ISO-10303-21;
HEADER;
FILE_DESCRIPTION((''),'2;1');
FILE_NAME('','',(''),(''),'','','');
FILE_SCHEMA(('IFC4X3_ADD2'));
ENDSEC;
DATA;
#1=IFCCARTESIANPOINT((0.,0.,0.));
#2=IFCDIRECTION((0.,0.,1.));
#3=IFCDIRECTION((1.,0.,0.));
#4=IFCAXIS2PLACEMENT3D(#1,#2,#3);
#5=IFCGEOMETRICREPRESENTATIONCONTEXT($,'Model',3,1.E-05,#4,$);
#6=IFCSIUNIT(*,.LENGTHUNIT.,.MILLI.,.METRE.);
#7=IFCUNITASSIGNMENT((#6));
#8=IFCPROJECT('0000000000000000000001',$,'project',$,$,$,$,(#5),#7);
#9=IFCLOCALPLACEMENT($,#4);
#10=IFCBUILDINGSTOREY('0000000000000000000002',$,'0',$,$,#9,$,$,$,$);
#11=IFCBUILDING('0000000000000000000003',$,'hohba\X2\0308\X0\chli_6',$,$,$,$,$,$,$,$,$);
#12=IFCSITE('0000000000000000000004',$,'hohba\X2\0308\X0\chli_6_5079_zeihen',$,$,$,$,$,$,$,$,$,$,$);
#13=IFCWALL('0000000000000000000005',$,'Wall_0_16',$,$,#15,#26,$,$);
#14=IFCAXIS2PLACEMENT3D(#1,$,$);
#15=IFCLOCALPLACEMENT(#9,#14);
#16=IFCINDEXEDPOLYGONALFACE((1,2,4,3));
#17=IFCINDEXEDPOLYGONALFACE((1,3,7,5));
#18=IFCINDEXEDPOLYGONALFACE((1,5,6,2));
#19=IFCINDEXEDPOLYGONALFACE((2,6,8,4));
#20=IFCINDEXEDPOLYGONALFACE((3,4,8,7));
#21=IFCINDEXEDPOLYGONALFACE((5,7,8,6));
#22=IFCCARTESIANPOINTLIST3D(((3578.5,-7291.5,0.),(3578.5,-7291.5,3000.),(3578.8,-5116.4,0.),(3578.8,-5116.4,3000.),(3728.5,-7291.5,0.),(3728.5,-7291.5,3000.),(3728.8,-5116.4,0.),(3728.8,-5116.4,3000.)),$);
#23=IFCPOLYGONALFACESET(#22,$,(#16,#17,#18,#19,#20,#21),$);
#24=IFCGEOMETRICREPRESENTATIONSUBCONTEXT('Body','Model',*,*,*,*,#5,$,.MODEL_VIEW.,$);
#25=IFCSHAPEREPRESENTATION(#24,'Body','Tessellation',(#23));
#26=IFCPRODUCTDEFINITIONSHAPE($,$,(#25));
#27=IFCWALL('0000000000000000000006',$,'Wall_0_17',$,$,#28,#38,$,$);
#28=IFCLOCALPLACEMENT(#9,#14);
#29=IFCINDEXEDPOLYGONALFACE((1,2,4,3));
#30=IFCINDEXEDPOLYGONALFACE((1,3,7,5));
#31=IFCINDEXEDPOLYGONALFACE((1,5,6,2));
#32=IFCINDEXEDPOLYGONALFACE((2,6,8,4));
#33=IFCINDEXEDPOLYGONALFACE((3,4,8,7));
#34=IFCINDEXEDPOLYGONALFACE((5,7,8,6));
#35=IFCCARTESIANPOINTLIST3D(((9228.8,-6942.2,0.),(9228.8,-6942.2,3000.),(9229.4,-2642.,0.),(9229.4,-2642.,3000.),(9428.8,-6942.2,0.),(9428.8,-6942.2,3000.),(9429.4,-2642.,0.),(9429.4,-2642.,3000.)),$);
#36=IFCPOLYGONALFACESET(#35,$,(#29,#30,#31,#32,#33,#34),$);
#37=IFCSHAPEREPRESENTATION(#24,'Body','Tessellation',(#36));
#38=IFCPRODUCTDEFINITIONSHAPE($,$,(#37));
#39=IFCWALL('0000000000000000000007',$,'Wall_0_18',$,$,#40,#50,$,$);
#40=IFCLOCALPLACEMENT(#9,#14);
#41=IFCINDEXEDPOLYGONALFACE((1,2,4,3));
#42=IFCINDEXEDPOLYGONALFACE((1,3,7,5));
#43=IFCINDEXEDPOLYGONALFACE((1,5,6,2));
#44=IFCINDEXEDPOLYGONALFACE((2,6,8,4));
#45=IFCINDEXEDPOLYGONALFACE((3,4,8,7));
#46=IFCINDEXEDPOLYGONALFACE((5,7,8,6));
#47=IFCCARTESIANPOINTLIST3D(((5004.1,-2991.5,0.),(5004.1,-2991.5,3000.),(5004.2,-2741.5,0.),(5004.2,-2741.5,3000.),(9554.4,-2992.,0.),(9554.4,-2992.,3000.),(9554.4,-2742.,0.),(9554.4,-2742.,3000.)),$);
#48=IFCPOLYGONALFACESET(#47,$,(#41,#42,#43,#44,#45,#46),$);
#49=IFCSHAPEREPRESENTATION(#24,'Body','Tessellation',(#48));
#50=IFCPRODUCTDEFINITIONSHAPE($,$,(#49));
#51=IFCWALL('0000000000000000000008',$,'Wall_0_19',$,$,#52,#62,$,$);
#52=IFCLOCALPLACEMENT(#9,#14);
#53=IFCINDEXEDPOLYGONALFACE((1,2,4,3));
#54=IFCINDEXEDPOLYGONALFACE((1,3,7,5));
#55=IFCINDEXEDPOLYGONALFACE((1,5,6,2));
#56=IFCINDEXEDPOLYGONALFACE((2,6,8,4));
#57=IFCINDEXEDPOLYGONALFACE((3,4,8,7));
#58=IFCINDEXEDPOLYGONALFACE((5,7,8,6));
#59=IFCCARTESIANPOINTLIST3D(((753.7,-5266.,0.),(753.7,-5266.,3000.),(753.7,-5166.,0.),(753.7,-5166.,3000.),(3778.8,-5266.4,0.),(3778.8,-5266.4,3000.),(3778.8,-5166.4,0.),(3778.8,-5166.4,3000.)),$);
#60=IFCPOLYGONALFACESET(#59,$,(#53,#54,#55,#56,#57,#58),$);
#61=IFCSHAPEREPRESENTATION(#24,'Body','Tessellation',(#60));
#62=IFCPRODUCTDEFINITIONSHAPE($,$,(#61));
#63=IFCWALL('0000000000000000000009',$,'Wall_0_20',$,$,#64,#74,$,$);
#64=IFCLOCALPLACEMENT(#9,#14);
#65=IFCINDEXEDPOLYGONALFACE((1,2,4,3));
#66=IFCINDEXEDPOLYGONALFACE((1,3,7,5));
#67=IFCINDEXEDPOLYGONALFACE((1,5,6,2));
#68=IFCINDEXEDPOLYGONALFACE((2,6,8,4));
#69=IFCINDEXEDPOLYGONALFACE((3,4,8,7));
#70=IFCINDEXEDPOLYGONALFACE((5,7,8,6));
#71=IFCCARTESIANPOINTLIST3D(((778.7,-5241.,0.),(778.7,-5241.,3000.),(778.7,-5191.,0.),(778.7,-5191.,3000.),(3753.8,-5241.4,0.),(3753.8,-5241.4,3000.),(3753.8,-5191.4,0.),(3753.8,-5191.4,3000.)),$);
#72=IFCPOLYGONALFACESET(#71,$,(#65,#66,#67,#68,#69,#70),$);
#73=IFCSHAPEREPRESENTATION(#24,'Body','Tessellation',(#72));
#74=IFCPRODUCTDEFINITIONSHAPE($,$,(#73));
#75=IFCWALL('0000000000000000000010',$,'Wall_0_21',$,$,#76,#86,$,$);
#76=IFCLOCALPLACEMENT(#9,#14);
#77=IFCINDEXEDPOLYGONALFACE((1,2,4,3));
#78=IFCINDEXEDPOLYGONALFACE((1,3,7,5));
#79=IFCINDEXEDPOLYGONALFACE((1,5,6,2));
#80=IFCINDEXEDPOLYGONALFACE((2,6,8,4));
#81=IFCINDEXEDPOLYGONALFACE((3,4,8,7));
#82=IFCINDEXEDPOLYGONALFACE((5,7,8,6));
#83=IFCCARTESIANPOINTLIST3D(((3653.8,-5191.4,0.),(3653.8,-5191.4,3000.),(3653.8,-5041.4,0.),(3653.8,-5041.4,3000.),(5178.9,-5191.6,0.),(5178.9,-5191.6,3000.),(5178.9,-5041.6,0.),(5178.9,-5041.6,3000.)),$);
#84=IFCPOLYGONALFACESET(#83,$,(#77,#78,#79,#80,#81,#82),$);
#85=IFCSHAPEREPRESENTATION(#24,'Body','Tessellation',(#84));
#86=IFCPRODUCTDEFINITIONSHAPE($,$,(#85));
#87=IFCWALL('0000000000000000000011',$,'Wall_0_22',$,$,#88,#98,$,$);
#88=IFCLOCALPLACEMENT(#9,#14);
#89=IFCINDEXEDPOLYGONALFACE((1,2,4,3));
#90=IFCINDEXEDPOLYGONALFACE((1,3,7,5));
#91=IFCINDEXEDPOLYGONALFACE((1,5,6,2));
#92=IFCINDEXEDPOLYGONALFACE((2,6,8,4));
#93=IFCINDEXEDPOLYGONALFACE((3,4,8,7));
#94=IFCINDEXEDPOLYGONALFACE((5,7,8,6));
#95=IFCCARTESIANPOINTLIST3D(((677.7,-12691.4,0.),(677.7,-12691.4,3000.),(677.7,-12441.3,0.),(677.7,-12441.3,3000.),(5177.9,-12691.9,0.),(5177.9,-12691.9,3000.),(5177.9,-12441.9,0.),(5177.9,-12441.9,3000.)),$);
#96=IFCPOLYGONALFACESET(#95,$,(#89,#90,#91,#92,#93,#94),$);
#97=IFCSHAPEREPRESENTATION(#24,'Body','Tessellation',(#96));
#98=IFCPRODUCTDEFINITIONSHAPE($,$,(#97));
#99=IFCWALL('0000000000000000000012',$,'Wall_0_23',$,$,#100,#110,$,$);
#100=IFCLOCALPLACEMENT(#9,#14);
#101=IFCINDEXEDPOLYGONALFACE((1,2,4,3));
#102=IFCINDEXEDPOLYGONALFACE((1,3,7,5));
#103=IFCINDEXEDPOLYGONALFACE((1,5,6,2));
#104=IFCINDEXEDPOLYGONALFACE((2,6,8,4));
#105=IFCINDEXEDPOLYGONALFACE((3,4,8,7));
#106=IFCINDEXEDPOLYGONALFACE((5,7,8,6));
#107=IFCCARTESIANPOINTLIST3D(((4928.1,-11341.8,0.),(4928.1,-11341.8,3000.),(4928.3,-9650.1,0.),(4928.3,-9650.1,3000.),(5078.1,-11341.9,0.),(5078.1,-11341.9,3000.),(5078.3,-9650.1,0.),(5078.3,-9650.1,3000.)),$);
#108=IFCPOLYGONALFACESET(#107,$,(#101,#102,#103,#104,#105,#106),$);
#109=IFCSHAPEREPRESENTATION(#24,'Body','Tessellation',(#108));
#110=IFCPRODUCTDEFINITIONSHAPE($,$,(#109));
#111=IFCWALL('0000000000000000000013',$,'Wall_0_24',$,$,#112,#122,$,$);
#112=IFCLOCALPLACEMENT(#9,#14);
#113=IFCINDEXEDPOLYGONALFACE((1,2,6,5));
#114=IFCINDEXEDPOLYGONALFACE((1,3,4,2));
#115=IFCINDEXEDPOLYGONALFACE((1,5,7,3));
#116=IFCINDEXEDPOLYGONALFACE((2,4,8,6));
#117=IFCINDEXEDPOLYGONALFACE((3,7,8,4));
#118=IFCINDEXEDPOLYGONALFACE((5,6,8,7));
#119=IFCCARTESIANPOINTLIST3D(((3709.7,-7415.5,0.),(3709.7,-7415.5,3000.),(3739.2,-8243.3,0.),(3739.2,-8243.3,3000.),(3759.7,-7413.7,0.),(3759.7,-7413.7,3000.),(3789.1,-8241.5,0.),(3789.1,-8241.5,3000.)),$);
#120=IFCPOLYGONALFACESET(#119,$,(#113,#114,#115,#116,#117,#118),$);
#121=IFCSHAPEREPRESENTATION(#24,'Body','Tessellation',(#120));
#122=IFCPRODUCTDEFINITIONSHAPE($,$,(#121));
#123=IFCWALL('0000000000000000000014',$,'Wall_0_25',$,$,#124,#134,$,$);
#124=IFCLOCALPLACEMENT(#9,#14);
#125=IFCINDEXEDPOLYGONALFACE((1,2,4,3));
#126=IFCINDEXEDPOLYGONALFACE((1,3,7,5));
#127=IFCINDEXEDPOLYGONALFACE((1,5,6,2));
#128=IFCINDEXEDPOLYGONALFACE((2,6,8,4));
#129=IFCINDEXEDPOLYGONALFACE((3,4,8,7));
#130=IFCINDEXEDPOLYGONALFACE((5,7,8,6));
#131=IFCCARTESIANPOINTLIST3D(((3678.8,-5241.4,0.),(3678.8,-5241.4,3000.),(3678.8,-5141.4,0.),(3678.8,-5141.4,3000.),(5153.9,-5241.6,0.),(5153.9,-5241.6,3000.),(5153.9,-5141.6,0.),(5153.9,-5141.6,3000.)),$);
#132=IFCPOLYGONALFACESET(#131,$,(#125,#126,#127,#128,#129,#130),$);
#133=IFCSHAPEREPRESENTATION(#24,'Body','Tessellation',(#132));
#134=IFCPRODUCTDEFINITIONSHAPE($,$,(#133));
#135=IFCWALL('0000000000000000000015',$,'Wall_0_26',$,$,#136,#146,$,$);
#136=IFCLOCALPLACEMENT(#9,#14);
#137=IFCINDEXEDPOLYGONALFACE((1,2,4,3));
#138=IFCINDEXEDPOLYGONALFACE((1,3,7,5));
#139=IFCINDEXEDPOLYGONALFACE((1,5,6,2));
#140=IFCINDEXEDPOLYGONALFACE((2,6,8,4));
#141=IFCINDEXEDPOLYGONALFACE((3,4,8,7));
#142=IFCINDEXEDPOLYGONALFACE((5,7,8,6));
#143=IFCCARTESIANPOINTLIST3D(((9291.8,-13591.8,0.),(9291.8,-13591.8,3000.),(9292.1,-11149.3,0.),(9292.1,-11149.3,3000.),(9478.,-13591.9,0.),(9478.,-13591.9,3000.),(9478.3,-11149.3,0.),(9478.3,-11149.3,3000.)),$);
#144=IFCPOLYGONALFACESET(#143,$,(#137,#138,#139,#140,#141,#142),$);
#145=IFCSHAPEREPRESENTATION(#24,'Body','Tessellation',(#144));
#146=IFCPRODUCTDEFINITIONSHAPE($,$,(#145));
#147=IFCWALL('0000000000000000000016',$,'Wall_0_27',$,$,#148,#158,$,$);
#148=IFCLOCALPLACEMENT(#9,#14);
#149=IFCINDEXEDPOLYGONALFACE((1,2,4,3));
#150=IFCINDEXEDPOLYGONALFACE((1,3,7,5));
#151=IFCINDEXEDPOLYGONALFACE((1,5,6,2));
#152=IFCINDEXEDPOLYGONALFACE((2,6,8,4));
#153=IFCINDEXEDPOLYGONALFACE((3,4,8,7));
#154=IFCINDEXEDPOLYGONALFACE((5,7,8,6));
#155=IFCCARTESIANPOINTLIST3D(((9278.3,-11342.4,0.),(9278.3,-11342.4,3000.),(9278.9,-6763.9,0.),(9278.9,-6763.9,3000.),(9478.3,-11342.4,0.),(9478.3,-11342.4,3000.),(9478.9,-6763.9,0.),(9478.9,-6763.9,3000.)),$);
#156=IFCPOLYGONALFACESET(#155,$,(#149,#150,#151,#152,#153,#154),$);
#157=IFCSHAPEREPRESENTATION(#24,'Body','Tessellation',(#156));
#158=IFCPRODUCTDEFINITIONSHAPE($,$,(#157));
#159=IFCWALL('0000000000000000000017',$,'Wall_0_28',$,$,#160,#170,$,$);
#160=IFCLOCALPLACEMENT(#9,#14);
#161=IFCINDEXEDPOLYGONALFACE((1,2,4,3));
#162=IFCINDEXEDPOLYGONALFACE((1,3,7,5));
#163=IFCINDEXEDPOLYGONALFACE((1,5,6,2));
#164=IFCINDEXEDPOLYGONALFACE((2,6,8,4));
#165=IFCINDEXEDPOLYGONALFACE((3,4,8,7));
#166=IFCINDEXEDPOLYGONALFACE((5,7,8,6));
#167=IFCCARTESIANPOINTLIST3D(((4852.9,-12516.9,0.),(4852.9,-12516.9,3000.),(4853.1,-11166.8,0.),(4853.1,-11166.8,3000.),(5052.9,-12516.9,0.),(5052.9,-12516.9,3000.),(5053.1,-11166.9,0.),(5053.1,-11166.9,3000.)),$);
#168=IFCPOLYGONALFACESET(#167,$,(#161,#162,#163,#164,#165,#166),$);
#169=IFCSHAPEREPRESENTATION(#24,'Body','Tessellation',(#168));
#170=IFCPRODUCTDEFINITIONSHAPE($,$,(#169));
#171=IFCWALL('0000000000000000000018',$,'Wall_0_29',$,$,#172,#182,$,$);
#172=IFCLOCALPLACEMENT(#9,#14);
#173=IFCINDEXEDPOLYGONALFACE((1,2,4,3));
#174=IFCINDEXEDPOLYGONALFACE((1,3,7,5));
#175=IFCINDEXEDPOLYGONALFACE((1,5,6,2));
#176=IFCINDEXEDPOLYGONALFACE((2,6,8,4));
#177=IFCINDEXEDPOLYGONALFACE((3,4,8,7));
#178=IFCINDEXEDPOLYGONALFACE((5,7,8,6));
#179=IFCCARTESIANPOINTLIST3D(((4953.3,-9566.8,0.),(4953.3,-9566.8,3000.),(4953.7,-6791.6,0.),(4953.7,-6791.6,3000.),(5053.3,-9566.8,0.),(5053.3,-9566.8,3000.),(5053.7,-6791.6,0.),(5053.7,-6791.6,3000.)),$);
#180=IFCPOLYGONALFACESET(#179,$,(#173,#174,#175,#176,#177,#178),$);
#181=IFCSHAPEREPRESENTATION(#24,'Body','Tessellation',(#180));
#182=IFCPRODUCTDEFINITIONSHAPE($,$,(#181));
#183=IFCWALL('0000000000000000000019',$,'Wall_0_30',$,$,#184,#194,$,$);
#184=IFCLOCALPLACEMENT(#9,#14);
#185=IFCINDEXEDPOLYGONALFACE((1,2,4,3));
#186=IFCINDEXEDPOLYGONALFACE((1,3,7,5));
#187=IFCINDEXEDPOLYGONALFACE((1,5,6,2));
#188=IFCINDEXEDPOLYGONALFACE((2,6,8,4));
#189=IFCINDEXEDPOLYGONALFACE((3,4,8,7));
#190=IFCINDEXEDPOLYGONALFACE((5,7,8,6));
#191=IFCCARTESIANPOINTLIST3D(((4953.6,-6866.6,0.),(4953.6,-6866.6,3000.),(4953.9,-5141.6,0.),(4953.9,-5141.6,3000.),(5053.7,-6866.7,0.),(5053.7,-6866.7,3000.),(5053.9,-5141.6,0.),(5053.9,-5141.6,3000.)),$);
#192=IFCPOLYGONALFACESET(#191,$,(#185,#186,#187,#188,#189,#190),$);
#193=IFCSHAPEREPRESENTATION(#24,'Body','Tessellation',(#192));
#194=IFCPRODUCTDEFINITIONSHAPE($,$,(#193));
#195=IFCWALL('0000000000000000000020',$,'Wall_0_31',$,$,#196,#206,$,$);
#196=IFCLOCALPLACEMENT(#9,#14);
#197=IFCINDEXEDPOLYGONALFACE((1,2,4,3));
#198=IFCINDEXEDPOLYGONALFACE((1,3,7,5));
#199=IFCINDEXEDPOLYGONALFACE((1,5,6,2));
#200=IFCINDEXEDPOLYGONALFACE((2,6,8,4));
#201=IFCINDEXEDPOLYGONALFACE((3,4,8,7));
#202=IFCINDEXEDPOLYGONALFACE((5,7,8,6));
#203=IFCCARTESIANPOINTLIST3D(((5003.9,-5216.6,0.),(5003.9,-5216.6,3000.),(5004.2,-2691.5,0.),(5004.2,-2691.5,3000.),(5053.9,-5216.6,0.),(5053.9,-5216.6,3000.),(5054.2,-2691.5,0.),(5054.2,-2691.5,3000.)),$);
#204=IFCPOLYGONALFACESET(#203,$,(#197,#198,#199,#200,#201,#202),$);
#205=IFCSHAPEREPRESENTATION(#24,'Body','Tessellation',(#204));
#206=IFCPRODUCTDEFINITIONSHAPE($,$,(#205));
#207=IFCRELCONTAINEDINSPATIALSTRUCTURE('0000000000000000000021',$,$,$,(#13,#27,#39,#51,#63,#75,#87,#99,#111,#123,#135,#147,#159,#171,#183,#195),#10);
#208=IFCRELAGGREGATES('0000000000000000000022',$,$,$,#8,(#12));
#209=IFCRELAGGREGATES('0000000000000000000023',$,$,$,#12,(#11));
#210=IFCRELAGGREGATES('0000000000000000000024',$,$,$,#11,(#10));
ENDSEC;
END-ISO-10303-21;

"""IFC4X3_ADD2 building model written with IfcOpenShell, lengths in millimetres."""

from ifc_helpers import new_model, si_unit, frame, origin_with_axes, place, context, subcontext, project, spatial, indexed_curve, outline, extrude, element, save


model = new_model("IFC4X3_ADD2")

# Units and contexts
model_context = context("Model", 3, precision=1e-05, world=origin_with_axes())
body_context = subcontext(model_context, "Body", "Model", "MODEL_VIEW")
ifc_project = project(units=[si_unit("LENGTHUNIT", "METRE", prefix="MILLI")], contexts=[model_context])

# Site, building, storey
site = spatial("IfcSite", under=ifc_project, Name="hohbächli_6_5079_zeihen")
building = spatial("IfcBuilding", under=site, Name="hohbächli_6")
storey_placement = place(None, origin_with_axes())
storey = spatial("IfcBuildingStorey", under=building, at=storey_placement, Name="0")

# Walls
wall_1_placement = place(storey_placement, frame((3728.5, -7291.5, 0.0), z_axis=(0.0, 0.0, 1.0), x_axis=(0.000129, 1.0, 0.0)))
element("IfcWall", 1, at=wall_1_placement, inside=storey, Name="Wall_0_16", context=body_context, shape_type="SweptSolid", body=[
    extrude(outline(indexed_curve([(0.0, 0.0), (0.0, 150.0), (2175.1, 150.0), (2175.1, 0.0), (0.0, 0.0)], self_intersect=False)), origin_with_axes(), (0.0, 0.0, 1.0), 3000.0),
])
wall_2_placement = place(storey_placement, frame((9428.8, -6942.2, 0.0), z_axis=(0.0, 0.0, 1.0), x_axis=(0.000129, 1.0, 0.0)))
element("IfcWall", 2, at=wall_2_placement, inside=storey, Name="Wall_0_17", context=body_context, shape_type="SweptSolid", body=[
    extrude(outline(indexed_curve([(0.0, 0.0), (0.0, 200.0), (4300.2, 200.0), (4300.2, 0.0), (0.0, 0.0)], self_intersect=False)), origin_with_axes(), (0.0, 0.0, 1.0), 3000.0),
])
wall_3_placement = place(storey_placement, frame((9554.4, -2742.0, 0.0), z_axis=(0.0, 0.0, 1.0), x_axis=(-1.0, 0.000129, 0.0)))
element("IfcWall", 3, at=wall_3_placement, inside=storey, Name="Wall_0_18", context=body_context, shape_type="SweptSolid", body=[
    extrude(outline(indexed_curve([(0.0, 0.0), (0.0, 250.0), (4550.2, 250.0), (4550.2, 0.0), (0.0, 0.0)], self_intersect=False)), origin_with_axes(), (0.0, 0.0, 1.0), 3000.0),
])
wall_4_placement = place(storey_placement, frame((3778.8, -5166.4, 0.0), z_axis=(0.0, 0.0, 1.0), x_axis=(-1.0, 0.000129, 0.0)))
element("IfcWall", 4, at=wall_4_placement, inside=storey, Name="Wall_0_19", context=body_context, shape_type="SweptSolid", body=[
    extrude(outline(indexed_curve([(0.0, 0.0), (0.0, 100.0), (3025.1, 100.0), (3025.1, 0.0), (0.0, 0.0)], self_intersect=False)), origin_with_axes(), (0.0, 0.0, 1.0), 3000.0),
])
wall_5_placement = place(storey_placement, frame((3753.8, -5191.4, 0.0), z_axis=(0.0, 0.0, 1.0), x_axis=(-1.0, 0.000129, 0.0)))
element("IfcWall", 5, at=wall_5_placement, inside=storey, Name="Wall_0_20", context=body_context, shape_type="SweptSolid", body=[
    extrude(outline(indexed_curve([(0.0, 0.0), (0.0, 50.0), (2975.1, 50.0), (2975.1, 0.0), (0.0, 0.0)], self_intersect=False)), origin_with_axes(), (0.0, 0.0, 1.0), 3000.0),
])
wall_6_placement = place(storey_placement, frame((3653.8, -5191.4, 0.0), z_axis=(0.0, 0.0, 1.0), x_axis=(1.0, -0.000129, 0.0)))
element("IfcWall", 6, at=wall_6_placement, inside=storey, Name="Wall_0_21", context=body_context, shape_type="SweptSolid", body=[
    extrude(outline(indexed_curve([(0.0, 0.0), (0.0, 150.0), (1525.1, 150.0), (1525.1, 0.0), (0.0, 0.0)], self_intersect=False)), origin_with_axes(), (0.0, 0.0, 1.0), 3000.0),
])
wall_7_placement = place(storey_placement, frame((5177.9, -12441.9, 0.0), z_axis=(0.0, 0.0, 1.0), x_axis=(-1.0, 0.000129, 0.0)))
element("IfcWall", 7, at=wall_7_placement, inside=storey, Name="Wall_0_22", context=body_context, shape_type="SweptSolid", body=[
    extrude(outline(indexed_curve([(0.0, 0.0), (0.0, 250.0), (4500.2, 250.0), (4500.2, 0.0), (0.0, 0.0)], self_intersect=False)), origin_with_axes(), (0.0, 0.0, 1.0), 3000.0),
])
wall_8_placement = place(storey_placement, frame((5078.1, -11341.9, 0.0), z_axis=(0.0, 0.0, 1.0), x_axis=(0.000129, 1.0, 0.0)))
element("IfcWall", 8, at=wall_8_placement, inside=storey, Name="Wall_0_23", context=body_context, shape_type="SweptSolid", body=[
    extrude(outline(indexed_curve([(0.0, 0.0), (0.0, 150.0), (1691.7, 150.0), (1691.7, 0.0), (0.0, 0.0)], self_intersect=False)), origin_with_axes(), (0.0, 0.0, 1.0), 3000.0),
])
wall_9_placement = place(storey_placement, frame((3789.1, -8241.5, 0.0), z_axis=(0.0, 0.0, 1.0), x_axis=(-0.035563, 0.999367, 0.0)))
element("IfcWall", 9, at=wall_9_placement, inside=storey, Name="Wall_0_24", context=body_context, shape_type="SweptSolid", body=[
    extrude(outline(indexed_curve([(0.0, 0.0), (0.0, 50.0), (828.4, 50.0), (828.4, 0.0), (0.0, 0.0)], self_intersect=False)), origin_with_axes(), (0.0, 0.0, 1.0), 3000.0),
])
wall_10_placement = place(storey_placement, frame((5153.9, -5141.6, 0.0), z_axis=(0.0, 0.0, 1.0), x_axis=(-1.0, 0.000129, 0.0)))
element("IfcWall", 10, at=wall_10_placement, inside=storey, Name="Wall_0_25", context=body_context, shape_type="SweptSolid", body=[
    extrude(outline(indexed_curve([(0.0, 0.0), (0.0, 100.0), (1475.1, 100.0), (1475.1, 0.0), (0.0, 0.0)], self_intersect=False)), origin_with_axes(), (0.0, 0.0, 1.0), 3000.0),
])
wall_11_placement = place(storey_placement, frame((9478.0, -13591.9, 0.0), z_axis=(0.0, 0.0, 1.0), x_axis=(0.000129, 1.0, 0.0)))
element("IfcWall", 11, at=wall_11_placement, inside=storey, Name="Wall_0_26", context=body_context, shape_type="SweptSolid", body=[
    extrude(outline(indexed_curve([(0.0, 0.0), (0.0, 186.2), (2442.5, 186.2), (2442.5, 0.0), (0.0, 0.0)], self_intersect=False)), origin_with_axes(), (0.0, 0.0, 1.0), 3000.0),
])
wall_12_placement = place(storey_placement, frame((9478.3, -11342.4, 0.0), z_axis=(0.0, 0.0, 1.0), x_axis=(0.000129, 1.0, 0.0)))
element("IfcWall", 12, at=wall_12_placement, inside=storey, Name="Wall_0_27", context=body_context, shape_type="SweptSolid", body=[
    extrude(outline(indexed_curve([(0.0, 0.0), (0.0, 200.0), (4578.5, 200.0), (4578.5, 0.0), (0.0, 0.0)], self_intersect=False)), origin_with_axes(), (0.0, 0.0, 1.0), 3000.0),
])
wall_13_placement = place(storey_placement, frame((5052.9, -12516.9, 0.0), z_axis=(0.0, 0.0, 1.0), x_axis=(0.000129, 1.0, 0.0)))
element("IfcWall", 13, at=wall_13_placement, inside=storey, Name="Wall_0_28", context=body_context, shape_type="SweptSolid", body=[
    extrude(outline(indexed_curve([(0.0, 0.0), (0.0, 200.0), (1350.1, 200.0), (1350.1, 0.0), (0.0, 0.0)], self_intersect=False)), origin_with_axes(), (0.0, 0.0, 1.0), 3000.0),
])
wall_14_placement = place(storey_placement, frame((5053.3, -9566.8, 0.0), z_axis=(0.0, 0.0, 1.0), x_axis=(0.000129, 1.0, 0.0)))
element("IfcWall", 14, at=wall_14_placement, inside=storey, Name="Wall_0_29", context=body_context, shape_type="SweptSolid", body=[
    extrude(outline(indexed_curve([(0.0, 0.0), (0.0, 100.0), (2775.1, 100.0), (2775.1, 0.0), (0.0, 0.0)], self_intersect=False)), origin_with_axes(), (0.0, 0.0, 1.0), 3000.0),
])
wall_15_placement = place(storey_placement, frame((5053.7, -6866.7, 0.0), z_axis=(0.0, 0.0, 1.0), x_axis=(0.000129, 1.0, 0.0)))
element("IfcWall", 15, at=wall_15_placement, inside=storey, Name="Wall_0_30", context=body_context, shape_type="SweptSolid", body=[
    extrude(outline(indexed_curve([(0.0, 0.0), (0.0, 100.0), (1725.1, 100.0), (1725.1, 0.0), (0.0, 0.0)], self_intersect=False)), origin_with_axes(), (0.0, 0.0, 1.0), 3000.0),
])
wall_16_placement = place(storey_placement, frame((5053.9, -5216.6, 0.0), z_axis=(0.0, 0.0, 1.0), x_axis=(0.000129, 1.0, 0.0)))
element("IfcWall", 16, at=wall_16_placement, inside=storey, Name="Wall_0_31", context=body_context, shape_type="SweptSolid", body=[
    extrude(outline(indexed_curve([(0.0, 0.0), (0.0, 50.0), (2525.1, 50.0), (2525.1, 0.0), (0.0, 0.0)], self_intersect=False)), origin_with_axes(), (0.0, 0.0, 1.0), 3000.0),
])

save(model, "model.ifc")
